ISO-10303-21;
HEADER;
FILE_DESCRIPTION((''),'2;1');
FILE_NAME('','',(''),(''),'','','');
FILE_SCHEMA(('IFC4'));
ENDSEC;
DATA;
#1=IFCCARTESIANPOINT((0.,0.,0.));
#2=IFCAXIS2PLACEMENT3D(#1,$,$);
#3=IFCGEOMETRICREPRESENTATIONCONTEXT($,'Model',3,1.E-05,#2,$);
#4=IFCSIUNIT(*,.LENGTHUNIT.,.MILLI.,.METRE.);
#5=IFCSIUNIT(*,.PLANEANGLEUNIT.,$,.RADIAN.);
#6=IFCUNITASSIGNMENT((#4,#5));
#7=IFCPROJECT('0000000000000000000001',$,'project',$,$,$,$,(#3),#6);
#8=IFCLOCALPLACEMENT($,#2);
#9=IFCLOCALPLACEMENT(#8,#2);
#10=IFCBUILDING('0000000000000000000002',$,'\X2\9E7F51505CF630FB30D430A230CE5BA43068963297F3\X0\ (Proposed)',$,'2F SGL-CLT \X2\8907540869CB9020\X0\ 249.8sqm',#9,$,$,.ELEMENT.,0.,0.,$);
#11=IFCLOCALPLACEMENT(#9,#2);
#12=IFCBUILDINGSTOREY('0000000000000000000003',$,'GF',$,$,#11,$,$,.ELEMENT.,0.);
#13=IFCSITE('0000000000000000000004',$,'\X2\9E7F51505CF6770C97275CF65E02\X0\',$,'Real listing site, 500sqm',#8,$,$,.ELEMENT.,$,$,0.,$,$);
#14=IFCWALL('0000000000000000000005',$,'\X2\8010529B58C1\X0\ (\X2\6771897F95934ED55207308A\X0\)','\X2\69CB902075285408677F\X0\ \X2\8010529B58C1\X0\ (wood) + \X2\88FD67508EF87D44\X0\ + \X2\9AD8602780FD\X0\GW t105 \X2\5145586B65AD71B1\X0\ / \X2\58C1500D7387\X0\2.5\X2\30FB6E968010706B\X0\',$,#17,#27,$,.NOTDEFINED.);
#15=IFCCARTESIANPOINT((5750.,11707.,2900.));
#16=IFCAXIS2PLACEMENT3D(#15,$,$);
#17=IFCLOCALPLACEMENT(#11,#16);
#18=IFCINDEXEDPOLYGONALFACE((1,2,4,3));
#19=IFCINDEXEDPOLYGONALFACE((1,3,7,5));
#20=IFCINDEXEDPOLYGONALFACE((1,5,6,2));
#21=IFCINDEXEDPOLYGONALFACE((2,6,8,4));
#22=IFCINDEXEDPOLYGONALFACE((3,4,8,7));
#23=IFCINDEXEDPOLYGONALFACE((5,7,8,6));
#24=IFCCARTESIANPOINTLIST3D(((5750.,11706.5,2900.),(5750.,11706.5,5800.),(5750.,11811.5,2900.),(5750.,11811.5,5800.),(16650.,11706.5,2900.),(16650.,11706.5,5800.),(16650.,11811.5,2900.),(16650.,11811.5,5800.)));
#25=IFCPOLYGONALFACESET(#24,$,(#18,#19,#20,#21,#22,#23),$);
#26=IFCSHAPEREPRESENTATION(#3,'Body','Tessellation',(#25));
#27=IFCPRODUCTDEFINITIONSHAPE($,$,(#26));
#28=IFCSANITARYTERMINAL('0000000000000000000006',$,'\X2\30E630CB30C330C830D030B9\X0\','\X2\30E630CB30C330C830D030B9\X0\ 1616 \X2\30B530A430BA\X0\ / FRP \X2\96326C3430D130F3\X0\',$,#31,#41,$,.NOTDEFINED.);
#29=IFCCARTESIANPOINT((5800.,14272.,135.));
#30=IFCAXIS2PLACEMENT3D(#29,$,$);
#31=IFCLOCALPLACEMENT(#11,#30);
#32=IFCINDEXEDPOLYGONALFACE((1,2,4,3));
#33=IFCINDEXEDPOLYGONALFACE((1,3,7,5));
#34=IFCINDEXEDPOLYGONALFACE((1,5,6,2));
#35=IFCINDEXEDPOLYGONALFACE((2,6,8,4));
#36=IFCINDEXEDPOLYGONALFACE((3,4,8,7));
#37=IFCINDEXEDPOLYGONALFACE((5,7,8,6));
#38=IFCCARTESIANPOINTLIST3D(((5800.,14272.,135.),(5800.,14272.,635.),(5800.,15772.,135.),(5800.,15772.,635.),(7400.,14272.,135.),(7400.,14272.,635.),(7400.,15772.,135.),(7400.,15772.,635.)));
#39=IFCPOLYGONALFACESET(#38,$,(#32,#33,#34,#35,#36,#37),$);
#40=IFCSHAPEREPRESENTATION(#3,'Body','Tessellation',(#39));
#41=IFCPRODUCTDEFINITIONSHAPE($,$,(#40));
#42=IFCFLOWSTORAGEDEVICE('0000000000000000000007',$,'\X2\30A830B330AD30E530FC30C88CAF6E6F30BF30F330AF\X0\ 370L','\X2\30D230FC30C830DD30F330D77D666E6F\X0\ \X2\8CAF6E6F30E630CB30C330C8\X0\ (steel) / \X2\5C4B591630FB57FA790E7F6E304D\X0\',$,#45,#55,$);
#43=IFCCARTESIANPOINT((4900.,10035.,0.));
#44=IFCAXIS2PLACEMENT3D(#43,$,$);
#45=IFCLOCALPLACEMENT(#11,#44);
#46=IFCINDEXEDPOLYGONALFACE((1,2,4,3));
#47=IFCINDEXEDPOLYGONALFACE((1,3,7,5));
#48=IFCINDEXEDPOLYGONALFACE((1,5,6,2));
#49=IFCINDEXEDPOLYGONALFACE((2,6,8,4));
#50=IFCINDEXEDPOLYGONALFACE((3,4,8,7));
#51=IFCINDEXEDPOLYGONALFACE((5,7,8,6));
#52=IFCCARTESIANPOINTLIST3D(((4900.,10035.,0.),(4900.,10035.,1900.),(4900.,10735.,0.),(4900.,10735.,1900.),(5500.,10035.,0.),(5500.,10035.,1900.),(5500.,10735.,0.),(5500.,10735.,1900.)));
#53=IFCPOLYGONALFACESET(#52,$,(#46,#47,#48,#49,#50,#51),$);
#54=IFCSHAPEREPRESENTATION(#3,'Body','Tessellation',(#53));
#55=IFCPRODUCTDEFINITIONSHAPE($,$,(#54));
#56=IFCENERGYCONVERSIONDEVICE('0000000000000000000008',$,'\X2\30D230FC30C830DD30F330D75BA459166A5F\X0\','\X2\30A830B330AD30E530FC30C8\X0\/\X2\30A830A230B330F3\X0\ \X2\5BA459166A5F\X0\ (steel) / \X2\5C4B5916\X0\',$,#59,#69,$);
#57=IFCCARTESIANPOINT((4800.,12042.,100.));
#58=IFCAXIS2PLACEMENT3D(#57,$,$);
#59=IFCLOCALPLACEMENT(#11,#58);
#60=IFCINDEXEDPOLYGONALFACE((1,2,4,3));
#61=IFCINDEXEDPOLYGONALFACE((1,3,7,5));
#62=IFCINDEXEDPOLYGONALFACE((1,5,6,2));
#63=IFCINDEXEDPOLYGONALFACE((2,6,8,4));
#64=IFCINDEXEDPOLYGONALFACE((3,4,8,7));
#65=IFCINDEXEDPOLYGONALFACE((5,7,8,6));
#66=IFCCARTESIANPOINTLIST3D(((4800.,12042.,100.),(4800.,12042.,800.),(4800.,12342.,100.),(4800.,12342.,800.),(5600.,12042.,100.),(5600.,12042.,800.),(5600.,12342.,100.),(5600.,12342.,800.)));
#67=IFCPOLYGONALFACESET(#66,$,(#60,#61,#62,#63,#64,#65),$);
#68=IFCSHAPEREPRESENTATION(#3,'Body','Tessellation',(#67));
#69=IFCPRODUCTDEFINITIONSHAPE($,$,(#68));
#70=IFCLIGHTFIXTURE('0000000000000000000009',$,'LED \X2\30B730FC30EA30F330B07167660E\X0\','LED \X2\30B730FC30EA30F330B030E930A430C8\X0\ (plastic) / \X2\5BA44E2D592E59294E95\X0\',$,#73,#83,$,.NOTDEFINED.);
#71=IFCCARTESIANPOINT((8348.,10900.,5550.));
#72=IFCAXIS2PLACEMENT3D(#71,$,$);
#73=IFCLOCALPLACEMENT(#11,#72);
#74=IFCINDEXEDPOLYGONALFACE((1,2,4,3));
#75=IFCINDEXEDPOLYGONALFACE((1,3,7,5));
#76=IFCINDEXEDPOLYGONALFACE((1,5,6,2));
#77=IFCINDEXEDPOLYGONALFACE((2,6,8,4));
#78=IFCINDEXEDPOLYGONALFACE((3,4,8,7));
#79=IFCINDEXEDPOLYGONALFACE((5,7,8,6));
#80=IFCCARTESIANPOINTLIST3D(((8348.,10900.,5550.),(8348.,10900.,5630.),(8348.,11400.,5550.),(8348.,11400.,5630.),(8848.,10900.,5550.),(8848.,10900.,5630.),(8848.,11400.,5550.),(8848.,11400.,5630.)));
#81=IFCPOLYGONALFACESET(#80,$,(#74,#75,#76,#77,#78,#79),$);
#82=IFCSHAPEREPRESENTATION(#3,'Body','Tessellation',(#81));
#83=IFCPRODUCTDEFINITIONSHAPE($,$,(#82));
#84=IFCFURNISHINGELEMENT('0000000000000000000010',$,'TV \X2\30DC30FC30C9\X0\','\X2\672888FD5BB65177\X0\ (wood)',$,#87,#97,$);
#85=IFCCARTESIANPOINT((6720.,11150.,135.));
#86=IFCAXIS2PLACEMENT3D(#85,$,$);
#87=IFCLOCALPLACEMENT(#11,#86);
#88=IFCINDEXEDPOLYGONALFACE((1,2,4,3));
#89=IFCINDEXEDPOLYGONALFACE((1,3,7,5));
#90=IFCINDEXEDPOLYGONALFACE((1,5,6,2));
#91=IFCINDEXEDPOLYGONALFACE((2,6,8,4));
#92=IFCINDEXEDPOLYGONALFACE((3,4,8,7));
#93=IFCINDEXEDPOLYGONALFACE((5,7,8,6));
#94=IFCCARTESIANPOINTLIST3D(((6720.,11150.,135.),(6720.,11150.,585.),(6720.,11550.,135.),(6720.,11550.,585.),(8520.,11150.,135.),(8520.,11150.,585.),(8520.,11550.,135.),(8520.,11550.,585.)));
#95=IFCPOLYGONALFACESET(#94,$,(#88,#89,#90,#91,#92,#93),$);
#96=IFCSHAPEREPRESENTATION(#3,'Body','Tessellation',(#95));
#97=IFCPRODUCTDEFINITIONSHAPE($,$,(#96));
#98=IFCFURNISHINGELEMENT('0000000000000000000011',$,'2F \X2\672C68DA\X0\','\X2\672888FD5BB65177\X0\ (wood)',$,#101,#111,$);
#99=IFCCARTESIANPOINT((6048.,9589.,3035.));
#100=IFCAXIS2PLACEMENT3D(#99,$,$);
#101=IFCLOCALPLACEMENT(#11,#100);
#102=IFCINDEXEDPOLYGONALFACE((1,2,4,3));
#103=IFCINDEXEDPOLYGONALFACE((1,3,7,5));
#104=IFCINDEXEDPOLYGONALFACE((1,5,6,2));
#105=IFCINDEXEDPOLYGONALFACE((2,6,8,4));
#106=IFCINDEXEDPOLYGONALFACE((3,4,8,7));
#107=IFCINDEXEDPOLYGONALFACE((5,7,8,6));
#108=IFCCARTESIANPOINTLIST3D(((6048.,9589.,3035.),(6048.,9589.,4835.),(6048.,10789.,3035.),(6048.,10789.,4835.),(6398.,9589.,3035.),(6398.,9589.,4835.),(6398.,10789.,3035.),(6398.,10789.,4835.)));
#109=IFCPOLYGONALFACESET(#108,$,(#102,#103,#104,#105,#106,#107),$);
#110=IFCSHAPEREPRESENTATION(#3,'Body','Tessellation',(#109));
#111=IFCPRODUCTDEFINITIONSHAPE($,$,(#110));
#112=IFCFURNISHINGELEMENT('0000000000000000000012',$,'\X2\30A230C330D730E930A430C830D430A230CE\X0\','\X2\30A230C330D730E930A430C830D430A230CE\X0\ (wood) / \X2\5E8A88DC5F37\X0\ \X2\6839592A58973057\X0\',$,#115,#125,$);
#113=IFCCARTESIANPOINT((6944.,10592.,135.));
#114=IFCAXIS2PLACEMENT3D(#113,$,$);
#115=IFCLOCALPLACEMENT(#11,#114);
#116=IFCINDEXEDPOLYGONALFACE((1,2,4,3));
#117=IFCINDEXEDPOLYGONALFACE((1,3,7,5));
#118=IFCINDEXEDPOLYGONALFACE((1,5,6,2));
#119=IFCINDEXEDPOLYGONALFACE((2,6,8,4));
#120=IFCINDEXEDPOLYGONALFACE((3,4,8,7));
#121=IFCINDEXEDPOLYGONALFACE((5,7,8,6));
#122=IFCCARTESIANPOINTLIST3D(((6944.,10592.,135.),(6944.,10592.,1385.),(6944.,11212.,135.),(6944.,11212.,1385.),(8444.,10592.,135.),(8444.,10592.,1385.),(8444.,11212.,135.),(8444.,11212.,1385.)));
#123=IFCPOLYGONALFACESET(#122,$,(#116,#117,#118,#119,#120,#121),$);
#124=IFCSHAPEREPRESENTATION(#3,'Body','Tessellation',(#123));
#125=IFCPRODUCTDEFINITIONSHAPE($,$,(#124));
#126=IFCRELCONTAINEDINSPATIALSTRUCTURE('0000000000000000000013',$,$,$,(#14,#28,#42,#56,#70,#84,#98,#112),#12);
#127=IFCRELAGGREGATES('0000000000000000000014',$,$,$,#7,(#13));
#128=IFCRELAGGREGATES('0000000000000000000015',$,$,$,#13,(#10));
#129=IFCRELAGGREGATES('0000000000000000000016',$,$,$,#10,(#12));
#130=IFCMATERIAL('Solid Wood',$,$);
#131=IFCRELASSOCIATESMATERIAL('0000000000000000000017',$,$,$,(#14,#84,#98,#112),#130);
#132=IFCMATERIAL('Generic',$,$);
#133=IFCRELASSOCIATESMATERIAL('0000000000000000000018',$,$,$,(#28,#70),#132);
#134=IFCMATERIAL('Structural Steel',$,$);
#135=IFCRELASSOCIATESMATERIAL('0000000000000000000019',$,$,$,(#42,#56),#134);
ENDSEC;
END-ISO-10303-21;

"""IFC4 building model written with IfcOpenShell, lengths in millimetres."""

from ifc_helpers import new_model, si_unit, frame, frame_2d, origin, place, context, project, spatial, rectangle, extrude, material, element, save


model = new_model("IFC4")

# Units and contexts
model_context = context("Model", 3, precision=1e-05, world=origin())
ifc_project = project(units=[si_unit("LENGTHUNIT", "METRE", prefix="MILLI"), si_unit("PLANEANGLEUNIT", "RADIAN")], contexts=[model_context])

# Site, building, storey
site_placement = place(None, origin())
site = spatial("IfcSite", under=ifc_project, at=site_placement, Name="鹿児島県霧島市", ObjectType="Real listing site, 500sqm", CompositionType="ELEMENT", RefElevation=0.0)
building_placement = place(site_placement, origin())
building = spatial("IfcBuilding", under=site, at=building_placement, Name="鹿児島・ピアノ室と防音 (Proposed)", ObjectType="2F SGL-CLT 複合構造 249.8sqm", CompositionType="ELEMENT", ElevationOfRefHeight=0.0, ElevationOfTerrain=0.0)
storey_placement = place(building_placement, origin())
storey = spatial("IfcBuildingStorey", under=building, at=storey_placement, Name="GF", CompositionType="ELEMENT", Elevation=0.0)

# Shared definitions
ifc_material_1 = material(Name="Solid Wood")

# Wall
wall_1_placement = place(storey_placement, frame((5750.0, 11707.0, 2900.0)))
element("IfcWall", 1, at=wall_1_placement, inside=storey, material=ifc_material_1, Name="耐力壁 (東西間仕切り)", Description="構造用合板 耐力壁 (wood) + 製材軸組 + 高性能GW t105 充填断熱 / 壁倍率2.5・準耐火", PredefinedType="NOTDEFINED", context=model_context, shape_type="SweptSolid", body=[
    extrude(rectangle(XDim=10900.0, YDim=105.0, at=frame_2d((5450.0, 52.0))), frame((5750.0, 11707.0, 2900.0)), (0.0, 0.0, 1.0), 2900.0),
])

# Sanitary terminal
ifc_material_2 = material(Name="Generic")
sanitary_terminal_placement = place(storey_placement, frame((5800.0, 14272.0, 135.0)))
element("IfcSanitaryTerminal", 2, at=sanitary_terminal_placement, inside=storey, material=ifc_material_2, Name="ユニットバス", Description="ユニットバス 1616 サイズ / FRP 防水パン", PredefinedType="NOTDEFINED", context=model_context, shape_type="SweptSolid", body=[
    extrude(rectangle(XDim=1600.0, YDim=1500.0, at=frame_2d((800.0, 750.0))), frame((5800.0, 14272.0, 135.0)), (0.0, 0.0, 1.0), 500.0),
])

# Flow storage device
ifc_material_3 = material(Name="Structural Steel")
flow_storage_device_placement = place(storey_placement, frame((4900.0, 10035.0, 0.0)))
element("IfcFlowStorageDevice", 3, at=flow_storage_device_placement, inside=storey, material=ifc_material_3, Name="エコキュート貯湯タンク 370L", Description="ヒートポンプ給湯 貯湯ユニット (steel) / 屋外・基礎置き", context=model_context, shape_type="SweptSolid", body=[
    extrude(rectangle(XDim=600.0, YDim=700.0, at=frame_2d((300.0, 350.0))), frame((4900.0, 10035.0, 0.0)), (0.0, 0.0, 1.0), 1900.0),
])

# Energy conversion device
energy_conversion_device_placement = place(storey_placement, frame((4800.0, 12042.0, 100.0)))
element("IfcEnergyConversionDevice", 4, at=energy_conversion_device_placement, inside=storey, material=ifc_material_3, Name="ヒートポンプ室外機", Description="エコキュート/エアコン 室外機 (steel) / 屋外", context=model_context, shape_type="SweptSolid", body=[
    extrude(rectangle(XDim=800.0, YDim=300.0, at=frame_2d((400.0, 150.0))), frame((4800.0, 12042.0, 100.0)), (0.0, 0.0, 1.0), 700.0),
])

# Light fixture
light_fixture_placement = place(storey_placement, frame((8348.0, 10900.0, 5550.0)))
element("IfcLightFixture", 5, at=light_fixture_placement, inside=storey, material=ifc_material_2, Name="LED シーリング照明", Description="LED シーリングライト (plastic) / 室中央天井", PredefinedType="NOTDEFINED", context=model_context, shape_type="SweptSolid", body=[
    extrude(rectangle(XDim=500.0, YDim=500.0, at=frame_2d((250.0, 250.0))), frame((8348.0, 10900.0, 5550.0)), (0.0, 0.0, 1.0), 80.0),
])

# Furnishing elements
furnishing_1_placement = place(storey_placement, frame((6720.0, 11150.0, 135.0)))
element("IfcFurnishingElement", 6, at=furnishing_1_placement, inside=storey, material=ifc_material_1, Name="TV ボード", Description="木製家具 (wood)", context=model_context, shape_type="SweptSolid", body=[
    extrude(rectangle(XDim=1800.0, YDim=400.0, at=frame_2d((900.0, 200.0))), frame((6720.0, 11150.0, 135.0)), (0.0, 0.0, 1.0), 450.0),
])
furnishing_2_placement = place(storey_placement, frame((6048.0, 9589.0, 3035.0)))
element("IfcFurnishingElement", 7, at=furnishing_2_placement, inside=storey, material=ifc_material_1, Name="2F 本棚", Description="木製家具 (wood)", context=model_context, shape_type="SweptSolid", body=[
    extrude(rectangle(XDim=350.0, YDim=1200.0, at=frame_2d((175.0, 600.0))), frame((6048.0, 9589.0, 3035.0)), (0.0, 0.0, 1.0), 1800.0),
])
furnishing_3_placement = place(storey_placement, frame((6944.0, 10592.0, 135.0)))
element("IfcFurnishingElement", 8, at=furnishing_3_placement, inside=storey, material=ifc_material_1, Name="アップライトピアノ", Description="アップライトピアノ (wood) / 床補強 根太増し", context=model_context, shape_type="SweptSolid", body=[
    extrude(rectangle(XDim=1500.0, YDim=620.0, at=frame_2d((750.0, 310.0))), frame((6944.0, 10592.0, 135.0)), (0.0, 0.0, 1.0), 1250.0),
])

save(model, "model.ifc")
